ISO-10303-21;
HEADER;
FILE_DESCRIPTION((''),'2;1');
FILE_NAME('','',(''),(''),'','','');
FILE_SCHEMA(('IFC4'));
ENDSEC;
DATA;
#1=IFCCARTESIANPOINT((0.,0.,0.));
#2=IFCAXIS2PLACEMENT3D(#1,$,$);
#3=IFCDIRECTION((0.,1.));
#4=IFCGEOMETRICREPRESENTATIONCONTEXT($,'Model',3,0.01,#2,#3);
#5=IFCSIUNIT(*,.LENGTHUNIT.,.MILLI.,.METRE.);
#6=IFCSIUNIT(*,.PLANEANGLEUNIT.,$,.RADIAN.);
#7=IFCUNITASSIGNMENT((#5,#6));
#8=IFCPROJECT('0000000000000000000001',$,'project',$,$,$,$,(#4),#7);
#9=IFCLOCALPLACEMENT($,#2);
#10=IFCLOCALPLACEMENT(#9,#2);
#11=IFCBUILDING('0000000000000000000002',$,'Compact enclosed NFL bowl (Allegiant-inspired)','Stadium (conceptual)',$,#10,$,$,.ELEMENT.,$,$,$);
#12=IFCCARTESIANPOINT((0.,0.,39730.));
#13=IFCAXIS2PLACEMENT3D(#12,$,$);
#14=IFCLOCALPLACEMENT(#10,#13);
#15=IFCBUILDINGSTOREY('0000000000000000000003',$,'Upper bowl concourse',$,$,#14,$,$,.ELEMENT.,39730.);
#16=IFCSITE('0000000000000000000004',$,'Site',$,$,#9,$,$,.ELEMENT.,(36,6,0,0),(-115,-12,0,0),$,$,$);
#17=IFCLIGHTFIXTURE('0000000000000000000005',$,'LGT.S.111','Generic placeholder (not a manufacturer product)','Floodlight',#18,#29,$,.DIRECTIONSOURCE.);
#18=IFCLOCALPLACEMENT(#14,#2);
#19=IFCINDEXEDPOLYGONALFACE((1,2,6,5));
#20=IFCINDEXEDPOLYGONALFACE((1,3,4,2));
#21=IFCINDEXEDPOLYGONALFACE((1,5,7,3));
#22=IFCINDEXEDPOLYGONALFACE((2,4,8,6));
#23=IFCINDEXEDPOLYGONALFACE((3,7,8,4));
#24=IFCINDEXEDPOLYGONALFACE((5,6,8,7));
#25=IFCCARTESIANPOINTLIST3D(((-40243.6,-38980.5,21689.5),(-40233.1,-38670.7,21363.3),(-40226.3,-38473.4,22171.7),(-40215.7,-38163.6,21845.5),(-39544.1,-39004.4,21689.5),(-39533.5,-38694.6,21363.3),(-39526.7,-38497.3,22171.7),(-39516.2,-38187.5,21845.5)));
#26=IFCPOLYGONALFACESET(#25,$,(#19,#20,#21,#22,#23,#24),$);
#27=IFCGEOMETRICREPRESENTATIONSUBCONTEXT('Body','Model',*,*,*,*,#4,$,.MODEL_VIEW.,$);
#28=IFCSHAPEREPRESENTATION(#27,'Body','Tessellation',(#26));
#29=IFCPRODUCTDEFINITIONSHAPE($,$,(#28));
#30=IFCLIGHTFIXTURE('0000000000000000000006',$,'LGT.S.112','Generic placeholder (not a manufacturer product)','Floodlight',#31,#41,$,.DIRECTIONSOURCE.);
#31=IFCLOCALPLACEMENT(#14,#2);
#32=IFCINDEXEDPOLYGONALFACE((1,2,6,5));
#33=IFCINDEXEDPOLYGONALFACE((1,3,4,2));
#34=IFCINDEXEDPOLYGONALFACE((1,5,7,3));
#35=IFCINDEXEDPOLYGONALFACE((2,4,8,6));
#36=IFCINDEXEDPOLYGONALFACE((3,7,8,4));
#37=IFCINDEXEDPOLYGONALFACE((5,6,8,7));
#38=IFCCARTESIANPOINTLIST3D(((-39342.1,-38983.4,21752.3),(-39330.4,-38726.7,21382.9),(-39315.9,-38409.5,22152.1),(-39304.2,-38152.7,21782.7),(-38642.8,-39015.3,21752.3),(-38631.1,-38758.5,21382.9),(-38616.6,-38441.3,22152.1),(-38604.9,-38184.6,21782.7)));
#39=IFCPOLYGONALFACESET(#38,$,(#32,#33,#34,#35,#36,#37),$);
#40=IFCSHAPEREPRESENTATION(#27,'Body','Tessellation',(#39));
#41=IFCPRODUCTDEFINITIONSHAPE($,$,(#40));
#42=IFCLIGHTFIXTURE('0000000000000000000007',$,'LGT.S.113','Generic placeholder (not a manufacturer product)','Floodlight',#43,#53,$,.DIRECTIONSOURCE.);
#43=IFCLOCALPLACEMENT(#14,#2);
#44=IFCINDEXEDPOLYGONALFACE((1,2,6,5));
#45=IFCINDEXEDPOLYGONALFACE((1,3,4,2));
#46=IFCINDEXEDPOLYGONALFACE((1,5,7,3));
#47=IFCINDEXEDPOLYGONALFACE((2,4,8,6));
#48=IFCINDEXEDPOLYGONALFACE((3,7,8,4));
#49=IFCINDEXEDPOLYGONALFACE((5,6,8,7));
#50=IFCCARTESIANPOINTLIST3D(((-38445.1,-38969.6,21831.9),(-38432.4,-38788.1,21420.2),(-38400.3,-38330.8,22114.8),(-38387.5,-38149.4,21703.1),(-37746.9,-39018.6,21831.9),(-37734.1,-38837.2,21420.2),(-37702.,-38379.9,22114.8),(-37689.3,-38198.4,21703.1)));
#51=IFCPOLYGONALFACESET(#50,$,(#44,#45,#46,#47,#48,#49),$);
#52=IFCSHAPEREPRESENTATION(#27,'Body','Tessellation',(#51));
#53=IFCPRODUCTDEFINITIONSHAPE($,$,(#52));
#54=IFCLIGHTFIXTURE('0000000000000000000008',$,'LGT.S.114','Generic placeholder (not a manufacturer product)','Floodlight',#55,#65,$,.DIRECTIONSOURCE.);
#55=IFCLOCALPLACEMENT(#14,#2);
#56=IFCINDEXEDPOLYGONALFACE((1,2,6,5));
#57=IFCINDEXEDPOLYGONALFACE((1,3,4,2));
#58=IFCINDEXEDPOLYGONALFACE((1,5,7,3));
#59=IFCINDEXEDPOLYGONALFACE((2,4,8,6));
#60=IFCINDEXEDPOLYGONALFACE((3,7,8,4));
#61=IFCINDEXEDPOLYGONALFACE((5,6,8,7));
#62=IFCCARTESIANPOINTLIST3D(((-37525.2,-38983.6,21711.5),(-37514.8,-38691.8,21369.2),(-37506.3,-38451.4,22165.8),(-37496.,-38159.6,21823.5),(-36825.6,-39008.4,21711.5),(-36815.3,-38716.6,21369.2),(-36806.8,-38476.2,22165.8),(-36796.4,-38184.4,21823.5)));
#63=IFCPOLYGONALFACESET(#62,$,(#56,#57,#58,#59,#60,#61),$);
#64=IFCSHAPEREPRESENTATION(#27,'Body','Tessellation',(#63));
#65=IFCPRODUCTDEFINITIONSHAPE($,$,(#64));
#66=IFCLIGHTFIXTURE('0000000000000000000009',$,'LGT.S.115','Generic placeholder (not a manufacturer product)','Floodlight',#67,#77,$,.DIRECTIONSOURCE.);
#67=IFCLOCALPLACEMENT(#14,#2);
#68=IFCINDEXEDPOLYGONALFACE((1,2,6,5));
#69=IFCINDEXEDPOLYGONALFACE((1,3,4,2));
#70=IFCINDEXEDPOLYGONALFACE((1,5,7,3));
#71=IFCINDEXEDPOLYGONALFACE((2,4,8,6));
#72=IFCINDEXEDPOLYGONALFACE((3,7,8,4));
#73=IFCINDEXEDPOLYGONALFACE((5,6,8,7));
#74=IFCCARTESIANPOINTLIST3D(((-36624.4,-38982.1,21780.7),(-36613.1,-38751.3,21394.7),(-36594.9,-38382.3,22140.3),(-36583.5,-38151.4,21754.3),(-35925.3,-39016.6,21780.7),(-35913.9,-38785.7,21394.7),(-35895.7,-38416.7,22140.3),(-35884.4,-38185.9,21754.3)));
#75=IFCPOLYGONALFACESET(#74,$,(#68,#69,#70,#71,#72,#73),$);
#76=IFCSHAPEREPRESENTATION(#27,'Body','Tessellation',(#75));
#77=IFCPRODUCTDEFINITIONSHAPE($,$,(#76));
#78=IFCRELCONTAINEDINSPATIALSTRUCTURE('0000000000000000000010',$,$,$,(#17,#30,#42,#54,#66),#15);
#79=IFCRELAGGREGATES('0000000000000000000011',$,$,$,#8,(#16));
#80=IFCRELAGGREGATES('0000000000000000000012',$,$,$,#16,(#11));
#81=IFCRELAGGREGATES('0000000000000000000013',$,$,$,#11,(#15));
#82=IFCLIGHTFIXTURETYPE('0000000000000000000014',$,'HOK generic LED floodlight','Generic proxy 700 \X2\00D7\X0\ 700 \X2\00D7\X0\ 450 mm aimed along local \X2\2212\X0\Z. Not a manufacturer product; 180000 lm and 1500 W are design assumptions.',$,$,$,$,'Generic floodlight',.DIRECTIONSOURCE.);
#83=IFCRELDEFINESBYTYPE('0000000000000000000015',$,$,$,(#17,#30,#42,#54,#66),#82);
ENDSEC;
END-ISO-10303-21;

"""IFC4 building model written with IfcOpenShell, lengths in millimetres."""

from ifc_helpers import new_model, si_unit, direction, frame, origin, place, context, subcontext, project, spatial, rectangle, extrude, source, transform, mapped, type_object, type_shapes, element, save


model = new_model("IFC4")

# Units and contexts
model_context = context("Model", 3, precision=0.01, world=origin(), true_north=direction((0.0, 1.0)))
body_context = subcontext(model_context, "Body", "Model", "MODEL_VIEW")
ifc_project = project(units=[si_unit("LENGTHUNIT", "METRE", prefix="MILLI"), si_unit("PLANEANGLEUNIT", "RADIAN")], contexts=[model_context])

# Site, building, storey
site_placement = place(None, origin())
site = spatial("IfcSite", under=ifc_project, at=site_placement, Name="Site", CompositionType="ELEMENT", RefLatitude=(36, 6, 0, 0), RefLongitude=(-115, -12, 0, 0))
building_placement = place(site_placement, origin())
building = spatial("IfcBuilding", under=site, at=building_placement, Name="Compact enclosed NFL bowl (Allegiant-inspired)", Description="Stadium (conceptual)", CompositionType="ELEMENT")
storey_placement = place(building_placement, frame((0.0, 0.0, 39730.0)))
storey = spatial("IfcBuildingStorey", under=building, at=storey_placement, Name="Upper bowl concourse", CompositionType="ELEMENT", Elevation=39730.0)

# Light fixtures
light_fixture_type = type_object("IfcLightFixtureType", Name="HOK generic LED floodlight", Description="Generic proxy 700 × 700 × 450 mm aimed along local −Z. Not a manufacturer product; 180000 lm and 1500 W are design assumptions.", ElementType="Generic floodlight", PredefinedType="DIRECTIONSOURCE")
shared_shape = source(origin(), body_context, "Body", "SweptSolid", [
    extrude(rectangle(XDim=700.0, YDim=700.0), frame((0.0, 0.0, -225.0)), (0.0, 0.0, 1.0), 450.0),
])
type_shapes(light_fixture_type, [shared_shape])
for number, where, z_axis, x_axis, name in (
    (1, (-39879.9, -38584.0, 21767.5), (-0.023505, -0.688422, 0.72493), (0.999418, -0.034124, 0.0), "LGT.S.111"),
    (2, (-38973.5, -38584.0, 21767.5), (-0.026009, -0.570622, 0.820801), (0.998963, -0.045532, 0.0), "LGT.S.112"),
    (3, (-38067.2, -38584.0, 21767.5), (-0.02831, -0.403162, 0.914691), (0.997544, -0.070047, 0.0), "LGT.S.113"),
    (4, (-37160.8, -38584.0, 21767.5), (-0.022987, -0.64856, 0.760816), (0.999372, -0.035421, 0.0), "LGT.S.114"),
    (5, (-36254.4, -38584.0, 21767.5), (-0.02529, -0.513078, 0.857969), (0.998787, -0.049231, 0.0), "LGT.S.115"),
):
    element("IfcLightFixture", number, at=place(storey_placement, frame(where, z_axis=z_axis, x_axis=x_axis)), inside=storey, type_object=light_fixture_type, Name=name, Description="Generic placeholder (not a manufacturer product)", ObjectType="Floodlight", PredefinedType="DIRECTIONSOURCE", context=body_context, shape_type="MappedRepresentation", body=[
        mapped(shared_shape, transform((0.0, 0.0, 0.0))),
    ])

save(model, "model.ifc")
